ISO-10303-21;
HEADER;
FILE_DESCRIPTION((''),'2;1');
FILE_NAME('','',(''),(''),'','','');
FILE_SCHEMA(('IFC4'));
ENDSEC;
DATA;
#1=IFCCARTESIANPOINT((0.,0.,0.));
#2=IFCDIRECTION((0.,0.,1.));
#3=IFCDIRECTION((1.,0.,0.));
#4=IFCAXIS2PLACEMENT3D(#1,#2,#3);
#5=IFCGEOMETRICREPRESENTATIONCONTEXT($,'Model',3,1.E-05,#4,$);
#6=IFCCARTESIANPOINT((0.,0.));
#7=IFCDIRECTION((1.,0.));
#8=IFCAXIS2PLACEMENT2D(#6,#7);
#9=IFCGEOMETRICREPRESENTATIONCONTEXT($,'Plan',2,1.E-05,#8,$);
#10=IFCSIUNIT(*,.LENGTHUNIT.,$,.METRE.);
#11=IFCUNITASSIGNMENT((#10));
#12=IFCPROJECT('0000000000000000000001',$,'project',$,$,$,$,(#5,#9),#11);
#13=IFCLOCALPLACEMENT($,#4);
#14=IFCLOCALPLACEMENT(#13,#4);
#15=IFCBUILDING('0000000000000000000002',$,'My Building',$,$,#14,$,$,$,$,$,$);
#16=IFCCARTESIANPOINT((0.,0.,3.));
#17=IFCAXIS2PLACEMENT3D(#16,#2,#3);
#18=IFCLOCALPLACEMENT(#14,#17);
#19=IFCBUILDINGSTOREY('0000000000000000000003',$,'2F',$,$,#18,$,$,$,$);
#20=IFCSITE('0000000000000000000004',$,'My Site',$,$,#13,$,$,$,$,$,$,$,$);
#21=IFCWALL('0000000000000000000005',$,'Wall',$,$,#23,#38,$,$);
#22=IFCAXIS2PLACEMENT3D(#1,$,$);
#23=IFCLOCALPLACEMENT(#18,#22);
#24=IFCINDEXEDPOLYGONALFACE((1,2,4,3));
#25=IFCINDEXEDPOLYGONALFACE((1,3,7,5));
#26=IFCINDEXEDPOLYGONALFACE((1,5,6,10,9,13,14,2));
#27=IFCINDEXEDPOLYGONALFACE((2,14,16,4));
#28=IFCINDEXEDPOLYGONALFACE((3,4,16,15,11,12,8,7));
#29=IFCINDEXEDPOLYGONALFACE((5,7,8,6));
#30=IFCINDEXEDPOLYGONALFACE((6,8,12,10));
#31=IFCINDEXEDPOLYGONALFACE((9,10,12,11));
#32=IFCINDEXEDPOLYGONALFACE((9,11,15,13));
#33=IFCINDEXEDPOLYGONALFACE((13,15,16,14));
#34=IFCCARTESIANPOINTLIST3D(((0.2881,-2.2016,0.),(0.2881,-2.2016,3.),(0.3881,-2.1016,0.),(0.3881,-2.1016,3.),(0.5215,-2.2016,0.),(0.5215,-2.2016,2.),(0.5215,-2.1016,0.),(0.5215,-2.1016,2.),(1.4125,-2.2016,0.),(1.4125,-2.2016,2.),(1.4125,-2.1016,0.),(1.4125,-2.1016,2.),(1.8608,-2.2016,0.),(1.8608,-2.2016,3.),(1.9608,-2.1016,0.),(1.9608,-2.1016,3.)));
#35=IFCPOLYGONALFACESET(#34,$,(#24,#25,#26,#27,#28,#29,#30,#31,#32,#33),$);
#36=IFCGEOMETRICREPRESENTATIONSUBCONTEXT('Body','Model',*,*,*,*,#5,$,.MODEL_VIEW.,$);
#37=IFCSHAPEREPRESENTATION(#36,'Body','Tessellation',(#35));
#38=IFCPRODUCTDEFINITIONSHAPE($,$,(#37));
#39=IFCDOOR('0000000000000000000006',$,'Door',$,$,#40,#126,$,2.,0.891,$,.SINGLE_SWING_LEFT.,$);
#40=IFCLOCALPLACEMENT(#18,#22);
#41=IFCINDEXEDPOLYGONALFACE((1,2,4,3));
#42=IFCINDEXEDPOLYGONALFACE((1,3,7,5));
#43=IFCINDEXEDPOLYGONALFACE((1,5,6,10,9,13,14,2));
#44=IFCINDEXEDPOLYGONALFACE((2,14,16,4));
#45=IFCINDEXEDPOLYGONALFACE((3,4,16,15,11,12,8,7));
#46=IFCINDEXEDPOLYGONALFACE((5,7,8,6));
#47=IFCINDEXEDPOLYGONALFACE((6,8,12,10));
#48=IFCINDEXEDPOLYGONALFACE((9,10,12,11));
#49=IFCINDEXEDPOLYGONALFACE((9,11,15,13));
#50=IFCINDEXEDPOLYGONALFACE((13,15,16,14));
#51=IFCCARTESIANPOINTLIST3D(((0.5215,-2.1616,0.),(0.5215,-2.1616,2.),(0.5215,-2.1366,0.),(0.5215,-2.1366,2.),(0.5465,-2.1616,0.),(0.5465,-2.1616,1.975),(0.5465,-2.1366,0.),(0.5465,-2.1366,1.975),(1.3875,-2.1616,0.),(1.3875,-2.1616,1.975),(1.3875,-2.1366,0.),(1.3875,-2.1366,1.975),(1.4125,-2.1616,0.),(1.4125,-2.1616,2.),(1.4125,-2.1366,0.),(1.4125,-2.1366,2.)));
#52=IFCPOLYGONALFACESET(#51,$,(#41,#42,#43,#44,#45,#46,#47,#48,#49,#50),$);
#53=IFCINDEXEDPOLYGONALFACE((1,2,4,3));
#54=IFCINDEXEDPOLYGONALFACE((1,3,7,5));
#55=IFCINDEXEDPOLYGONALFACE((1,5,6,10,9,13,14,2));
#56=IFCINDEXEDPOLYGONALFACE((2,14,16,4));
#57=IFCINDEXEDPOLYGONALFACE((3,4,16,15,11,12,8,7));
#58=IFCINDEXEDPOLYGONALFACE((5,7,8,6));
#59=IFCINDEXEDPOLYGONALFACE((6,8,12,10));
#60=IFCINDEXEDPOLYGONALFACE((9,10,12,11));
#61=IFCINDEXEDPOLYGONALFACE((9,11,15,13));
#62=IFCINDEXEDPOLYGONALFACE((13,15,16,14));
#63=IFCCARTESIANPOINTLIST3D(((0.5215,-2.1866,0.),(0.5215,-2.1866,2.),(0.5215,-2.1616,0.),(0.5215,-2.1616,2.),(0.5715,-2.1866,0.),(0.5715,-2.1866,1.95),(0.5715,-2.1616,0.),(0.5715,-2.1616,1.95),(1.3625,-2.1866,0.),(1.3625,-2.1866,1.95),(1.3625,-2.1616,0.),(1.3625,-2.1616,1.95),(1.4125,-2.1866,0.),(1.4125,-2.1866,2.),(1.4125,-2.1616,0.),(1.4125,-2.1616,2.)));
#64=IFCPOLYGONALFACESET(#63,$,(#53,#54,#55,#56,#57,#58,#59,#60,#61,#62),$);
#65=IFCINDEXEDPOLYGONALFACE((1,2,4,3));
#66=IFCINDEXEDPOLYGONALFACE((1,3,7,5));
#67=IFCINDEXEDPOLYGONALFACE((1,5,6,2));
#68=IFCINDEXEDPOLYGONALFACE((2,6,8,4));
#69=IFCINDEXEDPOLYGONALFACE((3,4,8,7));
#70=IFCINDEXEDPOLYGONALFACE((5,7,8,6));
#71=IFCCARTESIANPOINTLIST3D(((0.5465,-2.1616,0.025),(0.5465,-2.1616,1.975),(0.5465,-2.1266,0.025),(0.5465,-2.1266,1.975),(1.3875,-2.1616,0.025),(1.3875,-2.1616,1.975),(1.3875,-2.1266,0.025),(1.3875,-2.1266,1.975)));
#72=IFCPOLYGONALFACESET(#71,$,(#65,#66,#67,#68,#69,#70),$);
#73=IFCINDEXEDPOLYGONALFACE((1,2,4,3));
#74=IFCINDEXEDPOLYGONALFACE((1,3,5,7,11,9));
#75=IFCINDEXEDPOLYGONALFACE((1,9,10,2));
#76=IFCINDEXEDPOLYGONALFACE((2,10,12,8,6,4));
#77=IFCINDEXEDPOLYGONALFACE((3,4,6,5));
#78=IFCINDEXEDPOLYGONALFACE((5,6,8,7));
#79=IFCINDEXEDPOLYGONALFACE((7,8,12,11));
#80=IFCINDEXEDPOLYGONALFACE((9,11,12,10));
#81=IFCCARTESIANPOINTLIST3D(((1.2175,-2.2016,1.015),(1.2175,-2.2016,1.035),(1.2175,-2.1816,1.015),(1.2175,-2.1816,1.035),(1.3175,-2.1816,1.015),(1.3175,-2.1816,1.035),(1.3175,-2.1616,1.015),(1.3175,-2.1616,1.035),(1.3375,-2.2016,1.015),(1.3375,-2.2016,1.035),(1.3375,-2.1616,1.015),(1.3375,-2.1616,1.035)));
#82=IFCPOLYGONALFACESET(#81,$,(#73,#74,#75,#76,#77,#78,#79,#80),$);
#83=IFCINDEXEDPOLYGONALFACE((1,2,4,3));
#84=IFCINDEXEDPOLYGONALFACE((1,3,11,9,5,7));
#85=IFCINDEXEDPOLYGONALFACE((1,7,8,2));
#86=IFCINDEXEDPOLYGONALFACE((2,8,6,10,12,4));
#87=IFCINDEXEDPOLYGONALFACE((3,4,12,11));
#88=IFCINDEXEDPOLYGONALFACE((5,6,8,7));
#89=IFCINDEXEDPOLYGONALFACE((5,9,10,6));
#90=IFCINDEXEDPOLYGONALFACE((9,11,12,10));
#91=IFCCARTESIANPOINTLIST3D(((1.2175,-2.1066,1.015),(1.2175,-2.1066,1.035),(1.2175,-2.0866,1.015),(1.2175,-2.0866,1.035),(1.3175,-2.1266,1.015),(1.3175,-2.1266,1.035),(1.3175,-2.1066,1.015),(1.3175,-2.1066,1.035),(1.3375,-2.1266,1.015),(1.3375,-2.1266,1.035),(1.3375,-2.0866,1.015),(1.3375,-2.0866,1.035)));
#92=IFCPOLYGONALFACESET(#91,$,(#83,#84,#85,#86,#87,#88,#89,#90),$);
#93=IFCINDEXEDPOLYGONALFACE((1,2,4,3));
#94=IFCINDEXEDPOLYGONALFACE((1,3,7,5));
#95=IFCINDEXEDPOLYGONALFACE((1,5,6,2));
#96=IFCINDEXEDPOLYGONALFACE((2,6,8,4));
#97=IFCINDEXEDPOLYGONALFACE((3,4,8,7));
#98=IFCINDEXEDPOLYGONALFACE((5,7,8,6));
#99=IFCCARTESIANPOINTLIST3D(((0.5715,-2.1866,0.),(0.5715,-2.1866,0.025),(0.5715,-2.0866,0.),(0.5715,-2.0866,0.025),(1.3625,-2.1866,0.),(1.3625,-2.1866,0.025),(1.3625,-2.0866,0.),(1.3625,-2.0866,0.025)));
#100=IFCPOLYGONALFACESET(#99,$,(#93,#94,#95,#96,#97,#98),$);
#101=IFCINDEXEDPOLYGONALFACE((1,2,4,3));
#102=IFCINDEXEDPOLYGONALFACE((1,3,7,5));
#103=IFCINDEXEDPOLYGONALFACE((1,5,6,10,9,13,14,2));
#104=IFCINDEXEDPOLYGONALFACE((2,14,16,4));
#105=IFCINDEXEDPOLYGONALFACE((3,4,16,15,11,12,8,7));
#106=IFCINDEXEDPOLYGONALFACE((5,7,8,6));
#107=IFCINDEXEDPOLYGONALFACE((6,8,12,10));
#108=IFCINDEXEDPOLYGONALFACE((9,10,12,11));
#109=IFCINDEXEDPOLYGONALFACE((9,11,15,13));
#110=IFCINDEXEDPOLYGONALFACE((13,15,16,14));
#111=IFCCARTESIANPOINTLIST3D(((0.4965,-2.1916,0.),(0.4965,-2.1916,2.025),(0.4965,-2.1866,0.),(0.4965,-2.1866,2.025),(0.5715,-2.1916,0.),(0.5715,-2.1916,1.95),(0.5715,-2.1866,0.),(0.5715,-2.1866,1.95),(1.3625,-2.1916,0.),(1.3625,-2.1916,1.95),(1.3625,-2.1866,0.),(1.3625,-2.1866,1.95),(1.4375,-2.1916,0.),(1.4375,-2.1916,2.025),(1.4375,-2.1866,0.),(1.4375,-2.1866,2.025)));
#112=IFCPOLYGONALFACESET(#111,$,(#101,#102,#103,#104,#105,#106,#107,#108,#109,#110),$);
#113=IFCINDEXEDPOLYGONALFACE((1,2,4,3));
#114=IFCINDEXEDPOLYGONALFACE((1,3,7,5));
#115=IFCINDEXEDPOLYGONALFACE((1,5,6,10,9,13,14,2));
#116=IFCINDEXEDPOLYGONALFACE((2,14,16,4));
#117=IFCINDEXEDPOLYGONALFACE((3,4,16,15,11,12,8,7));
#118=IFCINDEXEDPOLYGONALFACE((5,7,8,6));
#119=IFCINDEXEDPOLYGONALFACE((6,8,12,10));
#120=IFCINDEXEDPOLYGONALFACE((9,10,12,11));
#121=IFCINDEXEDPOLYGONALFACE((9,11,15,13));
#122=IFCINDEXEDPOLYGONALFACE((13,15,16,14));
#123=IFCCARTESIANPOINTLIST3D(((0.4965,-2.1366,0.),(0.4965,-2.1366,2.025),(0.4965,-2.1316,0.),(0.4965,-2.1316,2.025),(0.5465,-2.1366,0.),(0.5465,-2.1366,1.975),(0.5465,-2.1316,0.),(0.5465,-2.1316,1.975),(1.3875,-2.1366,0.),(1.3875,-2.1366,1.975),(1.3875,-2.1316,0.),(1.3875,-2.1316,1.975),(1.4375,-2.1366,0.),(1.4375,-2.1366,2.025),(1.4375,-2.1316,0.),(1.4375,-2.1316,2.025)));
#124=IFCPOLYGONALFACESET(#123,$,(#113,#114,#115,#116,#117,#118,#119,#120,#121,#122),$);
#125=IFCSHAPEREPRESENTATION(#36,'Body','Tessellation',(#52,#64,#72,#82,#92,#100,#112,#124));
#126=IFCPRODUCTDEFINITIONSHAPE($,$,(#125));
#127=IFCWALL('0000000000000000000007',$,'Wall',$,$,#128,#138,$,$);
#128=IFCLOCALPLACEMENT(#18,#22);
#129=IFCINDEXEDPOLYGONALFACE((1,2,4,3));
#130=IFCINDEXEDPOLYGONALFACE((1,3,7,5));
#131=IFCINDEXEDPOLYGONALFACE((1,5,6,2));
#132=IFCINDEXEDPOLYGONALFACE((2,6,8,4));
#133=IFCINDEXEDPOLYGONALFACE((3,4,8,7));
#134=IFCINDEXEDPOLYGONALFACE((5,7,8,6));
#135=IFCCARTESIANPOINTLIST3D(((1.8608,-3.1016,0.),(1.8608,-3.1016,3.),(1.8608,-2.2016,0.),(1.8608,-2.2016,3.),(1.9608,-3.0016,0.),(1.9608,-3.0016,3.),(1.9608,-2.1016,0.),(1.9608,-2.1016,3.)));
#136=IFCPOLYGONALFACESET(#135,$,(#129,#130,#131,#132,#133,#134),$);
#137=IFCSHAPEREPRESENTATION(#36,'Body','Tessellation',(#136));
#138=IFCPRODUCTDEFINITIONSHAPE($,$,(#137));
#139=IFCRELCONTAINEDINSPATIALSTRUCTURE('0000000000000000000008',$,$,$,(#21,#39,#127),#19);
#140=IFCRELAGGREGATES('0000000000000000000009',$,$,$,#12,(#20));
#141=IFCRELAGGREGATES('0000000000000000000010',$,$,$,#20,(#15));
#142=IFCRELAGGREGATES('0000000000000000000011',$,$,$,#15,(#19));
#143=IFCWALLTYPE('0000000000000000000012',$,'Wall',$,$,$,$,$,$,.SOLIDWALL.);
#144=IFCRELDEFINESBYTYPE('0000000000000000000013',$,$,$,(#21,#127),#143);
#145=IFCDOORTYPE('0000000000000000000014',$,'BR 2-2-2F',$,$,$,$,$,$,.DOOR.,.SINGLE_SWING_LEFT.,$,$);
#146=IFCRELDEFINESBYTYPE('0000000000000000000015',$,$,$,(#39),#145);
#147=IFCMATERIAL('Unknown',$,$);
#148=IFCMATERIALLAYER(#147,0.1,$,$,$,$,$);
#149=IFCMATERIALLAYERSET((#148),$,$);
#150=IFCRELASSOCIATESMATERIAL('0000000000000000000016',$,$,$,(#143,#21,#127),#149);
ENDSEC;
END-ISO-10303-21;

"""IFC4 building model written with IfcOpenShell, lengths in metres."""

from ifc_helpers import new_model, entity, si_unit, frame, origin_with_axes, origin_2d_with_axis, place, context, subcontext, project, spatial, line, indexed_curve, outline, extrude, shape, source, transform, mapped, material, layer, layer_set, layer_usage, type_object, type_shapes, element, fill, save


model = new_model("IFC4")

# Units and contexts
model_context = context("Model", 3, precision=1e-05, world=origin_with_axes())
plan_context = context("Plan", 2, precision=1e-05, world=origin_2d_with_axis())
body_context_1 = subcontext(model_context, "Body", "Model", "MODEL_VIEW")
body_context_2 = subcontext(plan_context, "Body", "Plan", "PLAN_VIEW")
ifc_project = project(units=[si_unit("LENGTHUNIT", "METRE")], contexts=[model_context, plan_context])

# Site, building, storey
site_placement = place(None, origin_with_axes())
site = spatial("IfcSite", under=ifc_project, at=site_placement, Name="My Site")
building_placement = place(site_placement, origin_with_axes())
building = spatial("IfcBuilding", under=site, at=building_placement, Name="My Building")
storey_placement = place(building_placement, frame((0.0, 0.0, 3.0), z_axis=(0.0, 0.0, 1.0), x_axis=(1.0, 0.0, 0.0)))
storey = spatial("IfcBuildingStorey", under=building, at=storey_placement, Name="2F")

# Shared definitions
ifc_material = material(Name="Unknown")

# Shared definitions
ifc_layer_1 = layer(ifc_material, 0.1)
ifc_layer_set_1 = layer_set([ifc_layer_1])
wall_type = type_object("IfcWallType", Name="Wall", PredefinedType="SOLIDWALL", material=ifc_layer_set_1)

# Wall, opening, door
ifc_layer_usage_1 = layer_usage(ifc_layer_set_1, "AXIS2", "POSITIVE", 0.0)
wall_1_placement = place(storey_placement, frame((0.2881, -2.2016, 0.0), z_axis=(0.0, 0.0, 1.0), x_axis=(1.0, 0.0, 0.0)))
wall_1 = element("IfcWall", 1, at=wall_1_placement, inside=storey, type_object=wall_type, material=ifc_layer_usage_1, Name="Wall", context=body_context_1, shape_type="SweptSolid", body=[
    extrude(outline(indexed_curve([(0.0, 0.0), (0.1, 0.1), (1.6727, 0.1), (1.5727, 0.0)], segments=[line(1, 2, 3, 4, 1)])), origin_with_axes(), (0.0, 0.0, 1.0), 3.0),
])
shared_shape_1 = source(origin_with_axes(), body_context_1, "Body", "SweptSolid", [
    extrude(outline(indexed_curve([(0.0, 0.0), (0.891, 0.0), (0.891, 2.0), (0.0, 2.0)], segments=[line(1, 2, 3, 4, 1)])), frame((0.0, -0.6, 0.0), z_axis=(0.0, -1.0, 0.0), x_axis=(1.0, 0.0, 0.0)), (0.0, 0.0, -1.0), 1.2),
])
opening_1_placement = place(wall_1_placement, frame((0.2333, 0.015, 0.0), z_axis=(0.0, 0.0, 1.0), x_axis=(1.0, 0.0, 0.0)))
opening_1 = element("IfcOpeningElement", 2, at=opening_1_placement, cuts=wall_1, PredefinedType="OPENING", context=body_context_1, shape_type="MappedRepresentation", body=[
    mapped(shared_shape_1, transform((0.0, 0.0, 0.0), x_axis=(1.0, 0.0, 0.0), y_axis=(0.0, 1.0, 0.0), z_axis=(0.0, 0.0, 1.0), scale=1.0)),
])
door_type_1 = type_object("IfcDoorType", Name="BR 2-2-2F", OperationType="SINGLE_SWING_LEFT", PredefinedType="DOOR")
shared_shape_2 = source(origin_with_axes(), body_context_1, "Body", "SweptSolid", [
    extrude(outline(indexed_curve([(0.0, 0.0), (0.0, 2.0), (0.891, 2.0), (0.891, 0.0), (0.866, 0.0), (0.866, 1.975), (0.025, 1.975), (0.025, 0.0)], segments=[line(1, 2, 3, 4, 5, 6, 7, 8, 1)])), frame((0.0, 0.025, 0.0), z_axis=(0.0, -1.0, 0.0), x_axis=(1.0, 0.0, 0.0)), (0.0, 0.0, -1.0), 0.025),
    extrude(outline(indexed_curve([(0.0, 0.0), (0.0, 2.0), (0.891, 2.0), (0.891, 0.0), (0.841, 0.0), (0.841, 1.95), (0.05, 1.95), (0.05, 0.0)], segments=[line(1, 2, 3, 4, 5, 6, 7, 8, 1)])), frame((0.0, 0.0, 0.0), z_axis=(0.0, -1.0, 0.0), x_axis=(1.0, 0.0, 0.0)), (0.0, 0.0, -1.0), 0.025),
    extrude(outline(indexed_curve([(0.0, 0.0), (0.841, 0.0), (0.841, 0.035), (0.0, 0.035)], segments=[line(1, 2, 3, 4, 1)])), frame((0.025, 0.025, 0.025), z_axis=(0.0, 0.0, 1.0), x_axis=(1.0, 0.0, 0.0)), (0.0, 0.0, 1.0), 1.95),
    extrude(outline(indexed_curve([(0.0, 0.0), (0.0, -0.04), (-0.12, -0.04), (-0.12, -0.02), (-0.02, -0.02), (-0.02, 0.0)], segments=[line(1, 2, 3, 4, 5, 6, 1)])), frame((0.816, 0.025, 1.015), z_axis=(0.0, 0.0, 1.0), x_axis=(1.0, 0.0, 0.0)), (0.0, 0.0, 1.0), 0.02),
    extrude(outline(indexed_curve([(0.0, 0.0), (0.0, 0.04), (-0.12, 0.04), (-0.12, 0.02), (-0.02, 0.02), (-0.02, 0.0)], segments=[line(1, 2, 3, 4, 5, 6, 1)])), frame((0.816, 0.06, 1.015), z_axis=(0.0, 0.0, 1.0), x_axis=(1.0, 0.0, 0.0)), (0.0, 0.0, 1.0), 0.02),
    extrude(outline(indexed_curve([(0.0, 0.0), (0.791, 0.0), (0.791, 0.1), (0.0, 0.1)], segments=[line(1, 2, 3, 4, 1)])), frame((0.05, 0.0, 0.0), z_axis=(0.0, 0.0, 1.0), x_axis=(1.0, 0.0, 0.0)), (0.0, 0.0, 1.0), 0.025),
    extrude(outline(indexed_curve([(0.0, 0.0), (0.0, 2.025), (0.941, 2.025), (0.941, 0.0), (0.866, 0.0), (0.866, 1.95), (0.075, 1.95), (0.075, 0.0)], segments=[line(1, 2, 3, 4, 5, 6, 7, 8, 1)])), frame((-0.025, -0.005, 0.0), z_axis=(0.0, -1.0, 0.0), x_axis=(1.0, 0.0, 0.0)), (0.0, 0.0, -1.0), 0.005),
    extrude(outline(indexed_curve([(0.0, 0.0), (0.0, 2.025), (0.941, 2.025), (0.941, 0.0), (0.891, 0.0), (0.891, 1.975), (0.05, 1.975), (0.05, 0.0)], segments=[line(1, 2, 3, 4, 5, 6, 7, 8, 1)])), frame((-0.025, 0.05, 0.0), z_axis=(0.0, -1.0, 0.0), x_axis=(1.0, 0.0, 0.0)), (0.0, 0.0, -1.0), 0.005),
])
shared_shape_3 = source(origin_with_axes(), body_context_2, "Body", "Curve2D", [
    entity("IfcIndexedPolyCurve", entity("IfcCartesianPointList2D", [[0.0, 0.0], [0.0, 0.05], [0.025, 0.05], [0.025, 0.025], [0.05, 0.025], [0.05, 0.0]]), [entity("IfcLineIndex", [1, 2, 3, 4, 5, 6, 1])]),
    entity("IfcIndexedPolyCurve", entity("IfcCartesianPointList2D", [[0.891, 0.0], [0.891, 0.05], [0.866, 0.05], [0.866, 0.025], [0.841, 0.025], [0.841, 0.0]]), [entity("IfcLineIndex", [1, 2, 3, 4, 5, 6, 1])]),
    entity("IfcTrimmedCurve", entity("IfcEllipse", entity("IfcAxis2Placement2D", entity("IfcCartesianPoint", [0.06, 0.05]), entity("IfcDirection", [1.0, 0.0])), 0.806, 0.841), [entity("IfcCartesianPoint", [0.866, 0.05])], [entity("IfcCartesianPoint", [0.06, 0.891])], True, "CARTESIAN"),
    entity("IfcIndexedPolyCurve", entity("IfcCartesianPointList2D", [[0.025, 0.05], [0.06, 0.05], [0.06, 0.891], [0.025, 0.891]]), [entity("IfcLineIndex", [1, 2, 3, 4, 1])]),
])
type_shapes(door_type_1, [shared_shape_2, shared_shape_3])
door_1_placement = place(opening_1_placement, frame((0.0, 0.0, 0.0), z_axis=(0.0, 0.0, 1.0), x_axis=(1.0, 0.0, 0.0)))
door_1 = element("IfcDoor", 3, at=door_1_placement, inside=storey, type_object=door_type_1, Name="Door", OperationType="SINGLE_SWING_LEFT", OverallHeight=2.0, OverallWidth=0.891, shapes=[
    shape(body_context_1, "Body", "MappedRepresentation", [mapped(shared_shape_2, transform((0.0, 0.0, 0.0), x_axis=(1.0, 0.0, 0.0), y_axis=(0.0, 1.0, 0.0), z_axis=(0.0, 0.0, 1.0), scale=1.0))]),
    shape(body_context_2, "Body", "MappedRepresentation", [mapped(shared_shape_3, transform((0.0, 0.0, 0.0), x_axis=(1.0, 0.0, 0.0), y_axis=(0.0, 1.0, 0.0), z_axis=(0.0, 0.0, 1.0), scale=1.0))]),
])
fill(opening_1, door_1)

# Wall
ifc_layer_usage_2 = layer_usage(ifc_layer_set_1, "AXIS2", "POSITIVE", 0.0)
wall_2_placement = place(storey_placement, frame((1.8608, -2.2016, 0.0), z_axis=(0.0, 0.0, 1.0), x_axis=(0.0, -1.0, 0.0)))
element("IfcWall", 4, at=wall_2_placement, inside=storey, type_object=wall_type, material=ifc_layer_usage_2, Name="Wall", context=body_context_1, shape_type="SweptSolid", body=[
    extrude(outline(indexed_curve([(0.0, 0.0), (-0.1, 0.1), (0.8, 0.1), (0.9, 0.0)], segments=[line(1, 2, 3, 4, 1)])), origin_with_axes(), (0.0, 0.0, 1.0), 3.0),
])

save(model, "model.ifc")
